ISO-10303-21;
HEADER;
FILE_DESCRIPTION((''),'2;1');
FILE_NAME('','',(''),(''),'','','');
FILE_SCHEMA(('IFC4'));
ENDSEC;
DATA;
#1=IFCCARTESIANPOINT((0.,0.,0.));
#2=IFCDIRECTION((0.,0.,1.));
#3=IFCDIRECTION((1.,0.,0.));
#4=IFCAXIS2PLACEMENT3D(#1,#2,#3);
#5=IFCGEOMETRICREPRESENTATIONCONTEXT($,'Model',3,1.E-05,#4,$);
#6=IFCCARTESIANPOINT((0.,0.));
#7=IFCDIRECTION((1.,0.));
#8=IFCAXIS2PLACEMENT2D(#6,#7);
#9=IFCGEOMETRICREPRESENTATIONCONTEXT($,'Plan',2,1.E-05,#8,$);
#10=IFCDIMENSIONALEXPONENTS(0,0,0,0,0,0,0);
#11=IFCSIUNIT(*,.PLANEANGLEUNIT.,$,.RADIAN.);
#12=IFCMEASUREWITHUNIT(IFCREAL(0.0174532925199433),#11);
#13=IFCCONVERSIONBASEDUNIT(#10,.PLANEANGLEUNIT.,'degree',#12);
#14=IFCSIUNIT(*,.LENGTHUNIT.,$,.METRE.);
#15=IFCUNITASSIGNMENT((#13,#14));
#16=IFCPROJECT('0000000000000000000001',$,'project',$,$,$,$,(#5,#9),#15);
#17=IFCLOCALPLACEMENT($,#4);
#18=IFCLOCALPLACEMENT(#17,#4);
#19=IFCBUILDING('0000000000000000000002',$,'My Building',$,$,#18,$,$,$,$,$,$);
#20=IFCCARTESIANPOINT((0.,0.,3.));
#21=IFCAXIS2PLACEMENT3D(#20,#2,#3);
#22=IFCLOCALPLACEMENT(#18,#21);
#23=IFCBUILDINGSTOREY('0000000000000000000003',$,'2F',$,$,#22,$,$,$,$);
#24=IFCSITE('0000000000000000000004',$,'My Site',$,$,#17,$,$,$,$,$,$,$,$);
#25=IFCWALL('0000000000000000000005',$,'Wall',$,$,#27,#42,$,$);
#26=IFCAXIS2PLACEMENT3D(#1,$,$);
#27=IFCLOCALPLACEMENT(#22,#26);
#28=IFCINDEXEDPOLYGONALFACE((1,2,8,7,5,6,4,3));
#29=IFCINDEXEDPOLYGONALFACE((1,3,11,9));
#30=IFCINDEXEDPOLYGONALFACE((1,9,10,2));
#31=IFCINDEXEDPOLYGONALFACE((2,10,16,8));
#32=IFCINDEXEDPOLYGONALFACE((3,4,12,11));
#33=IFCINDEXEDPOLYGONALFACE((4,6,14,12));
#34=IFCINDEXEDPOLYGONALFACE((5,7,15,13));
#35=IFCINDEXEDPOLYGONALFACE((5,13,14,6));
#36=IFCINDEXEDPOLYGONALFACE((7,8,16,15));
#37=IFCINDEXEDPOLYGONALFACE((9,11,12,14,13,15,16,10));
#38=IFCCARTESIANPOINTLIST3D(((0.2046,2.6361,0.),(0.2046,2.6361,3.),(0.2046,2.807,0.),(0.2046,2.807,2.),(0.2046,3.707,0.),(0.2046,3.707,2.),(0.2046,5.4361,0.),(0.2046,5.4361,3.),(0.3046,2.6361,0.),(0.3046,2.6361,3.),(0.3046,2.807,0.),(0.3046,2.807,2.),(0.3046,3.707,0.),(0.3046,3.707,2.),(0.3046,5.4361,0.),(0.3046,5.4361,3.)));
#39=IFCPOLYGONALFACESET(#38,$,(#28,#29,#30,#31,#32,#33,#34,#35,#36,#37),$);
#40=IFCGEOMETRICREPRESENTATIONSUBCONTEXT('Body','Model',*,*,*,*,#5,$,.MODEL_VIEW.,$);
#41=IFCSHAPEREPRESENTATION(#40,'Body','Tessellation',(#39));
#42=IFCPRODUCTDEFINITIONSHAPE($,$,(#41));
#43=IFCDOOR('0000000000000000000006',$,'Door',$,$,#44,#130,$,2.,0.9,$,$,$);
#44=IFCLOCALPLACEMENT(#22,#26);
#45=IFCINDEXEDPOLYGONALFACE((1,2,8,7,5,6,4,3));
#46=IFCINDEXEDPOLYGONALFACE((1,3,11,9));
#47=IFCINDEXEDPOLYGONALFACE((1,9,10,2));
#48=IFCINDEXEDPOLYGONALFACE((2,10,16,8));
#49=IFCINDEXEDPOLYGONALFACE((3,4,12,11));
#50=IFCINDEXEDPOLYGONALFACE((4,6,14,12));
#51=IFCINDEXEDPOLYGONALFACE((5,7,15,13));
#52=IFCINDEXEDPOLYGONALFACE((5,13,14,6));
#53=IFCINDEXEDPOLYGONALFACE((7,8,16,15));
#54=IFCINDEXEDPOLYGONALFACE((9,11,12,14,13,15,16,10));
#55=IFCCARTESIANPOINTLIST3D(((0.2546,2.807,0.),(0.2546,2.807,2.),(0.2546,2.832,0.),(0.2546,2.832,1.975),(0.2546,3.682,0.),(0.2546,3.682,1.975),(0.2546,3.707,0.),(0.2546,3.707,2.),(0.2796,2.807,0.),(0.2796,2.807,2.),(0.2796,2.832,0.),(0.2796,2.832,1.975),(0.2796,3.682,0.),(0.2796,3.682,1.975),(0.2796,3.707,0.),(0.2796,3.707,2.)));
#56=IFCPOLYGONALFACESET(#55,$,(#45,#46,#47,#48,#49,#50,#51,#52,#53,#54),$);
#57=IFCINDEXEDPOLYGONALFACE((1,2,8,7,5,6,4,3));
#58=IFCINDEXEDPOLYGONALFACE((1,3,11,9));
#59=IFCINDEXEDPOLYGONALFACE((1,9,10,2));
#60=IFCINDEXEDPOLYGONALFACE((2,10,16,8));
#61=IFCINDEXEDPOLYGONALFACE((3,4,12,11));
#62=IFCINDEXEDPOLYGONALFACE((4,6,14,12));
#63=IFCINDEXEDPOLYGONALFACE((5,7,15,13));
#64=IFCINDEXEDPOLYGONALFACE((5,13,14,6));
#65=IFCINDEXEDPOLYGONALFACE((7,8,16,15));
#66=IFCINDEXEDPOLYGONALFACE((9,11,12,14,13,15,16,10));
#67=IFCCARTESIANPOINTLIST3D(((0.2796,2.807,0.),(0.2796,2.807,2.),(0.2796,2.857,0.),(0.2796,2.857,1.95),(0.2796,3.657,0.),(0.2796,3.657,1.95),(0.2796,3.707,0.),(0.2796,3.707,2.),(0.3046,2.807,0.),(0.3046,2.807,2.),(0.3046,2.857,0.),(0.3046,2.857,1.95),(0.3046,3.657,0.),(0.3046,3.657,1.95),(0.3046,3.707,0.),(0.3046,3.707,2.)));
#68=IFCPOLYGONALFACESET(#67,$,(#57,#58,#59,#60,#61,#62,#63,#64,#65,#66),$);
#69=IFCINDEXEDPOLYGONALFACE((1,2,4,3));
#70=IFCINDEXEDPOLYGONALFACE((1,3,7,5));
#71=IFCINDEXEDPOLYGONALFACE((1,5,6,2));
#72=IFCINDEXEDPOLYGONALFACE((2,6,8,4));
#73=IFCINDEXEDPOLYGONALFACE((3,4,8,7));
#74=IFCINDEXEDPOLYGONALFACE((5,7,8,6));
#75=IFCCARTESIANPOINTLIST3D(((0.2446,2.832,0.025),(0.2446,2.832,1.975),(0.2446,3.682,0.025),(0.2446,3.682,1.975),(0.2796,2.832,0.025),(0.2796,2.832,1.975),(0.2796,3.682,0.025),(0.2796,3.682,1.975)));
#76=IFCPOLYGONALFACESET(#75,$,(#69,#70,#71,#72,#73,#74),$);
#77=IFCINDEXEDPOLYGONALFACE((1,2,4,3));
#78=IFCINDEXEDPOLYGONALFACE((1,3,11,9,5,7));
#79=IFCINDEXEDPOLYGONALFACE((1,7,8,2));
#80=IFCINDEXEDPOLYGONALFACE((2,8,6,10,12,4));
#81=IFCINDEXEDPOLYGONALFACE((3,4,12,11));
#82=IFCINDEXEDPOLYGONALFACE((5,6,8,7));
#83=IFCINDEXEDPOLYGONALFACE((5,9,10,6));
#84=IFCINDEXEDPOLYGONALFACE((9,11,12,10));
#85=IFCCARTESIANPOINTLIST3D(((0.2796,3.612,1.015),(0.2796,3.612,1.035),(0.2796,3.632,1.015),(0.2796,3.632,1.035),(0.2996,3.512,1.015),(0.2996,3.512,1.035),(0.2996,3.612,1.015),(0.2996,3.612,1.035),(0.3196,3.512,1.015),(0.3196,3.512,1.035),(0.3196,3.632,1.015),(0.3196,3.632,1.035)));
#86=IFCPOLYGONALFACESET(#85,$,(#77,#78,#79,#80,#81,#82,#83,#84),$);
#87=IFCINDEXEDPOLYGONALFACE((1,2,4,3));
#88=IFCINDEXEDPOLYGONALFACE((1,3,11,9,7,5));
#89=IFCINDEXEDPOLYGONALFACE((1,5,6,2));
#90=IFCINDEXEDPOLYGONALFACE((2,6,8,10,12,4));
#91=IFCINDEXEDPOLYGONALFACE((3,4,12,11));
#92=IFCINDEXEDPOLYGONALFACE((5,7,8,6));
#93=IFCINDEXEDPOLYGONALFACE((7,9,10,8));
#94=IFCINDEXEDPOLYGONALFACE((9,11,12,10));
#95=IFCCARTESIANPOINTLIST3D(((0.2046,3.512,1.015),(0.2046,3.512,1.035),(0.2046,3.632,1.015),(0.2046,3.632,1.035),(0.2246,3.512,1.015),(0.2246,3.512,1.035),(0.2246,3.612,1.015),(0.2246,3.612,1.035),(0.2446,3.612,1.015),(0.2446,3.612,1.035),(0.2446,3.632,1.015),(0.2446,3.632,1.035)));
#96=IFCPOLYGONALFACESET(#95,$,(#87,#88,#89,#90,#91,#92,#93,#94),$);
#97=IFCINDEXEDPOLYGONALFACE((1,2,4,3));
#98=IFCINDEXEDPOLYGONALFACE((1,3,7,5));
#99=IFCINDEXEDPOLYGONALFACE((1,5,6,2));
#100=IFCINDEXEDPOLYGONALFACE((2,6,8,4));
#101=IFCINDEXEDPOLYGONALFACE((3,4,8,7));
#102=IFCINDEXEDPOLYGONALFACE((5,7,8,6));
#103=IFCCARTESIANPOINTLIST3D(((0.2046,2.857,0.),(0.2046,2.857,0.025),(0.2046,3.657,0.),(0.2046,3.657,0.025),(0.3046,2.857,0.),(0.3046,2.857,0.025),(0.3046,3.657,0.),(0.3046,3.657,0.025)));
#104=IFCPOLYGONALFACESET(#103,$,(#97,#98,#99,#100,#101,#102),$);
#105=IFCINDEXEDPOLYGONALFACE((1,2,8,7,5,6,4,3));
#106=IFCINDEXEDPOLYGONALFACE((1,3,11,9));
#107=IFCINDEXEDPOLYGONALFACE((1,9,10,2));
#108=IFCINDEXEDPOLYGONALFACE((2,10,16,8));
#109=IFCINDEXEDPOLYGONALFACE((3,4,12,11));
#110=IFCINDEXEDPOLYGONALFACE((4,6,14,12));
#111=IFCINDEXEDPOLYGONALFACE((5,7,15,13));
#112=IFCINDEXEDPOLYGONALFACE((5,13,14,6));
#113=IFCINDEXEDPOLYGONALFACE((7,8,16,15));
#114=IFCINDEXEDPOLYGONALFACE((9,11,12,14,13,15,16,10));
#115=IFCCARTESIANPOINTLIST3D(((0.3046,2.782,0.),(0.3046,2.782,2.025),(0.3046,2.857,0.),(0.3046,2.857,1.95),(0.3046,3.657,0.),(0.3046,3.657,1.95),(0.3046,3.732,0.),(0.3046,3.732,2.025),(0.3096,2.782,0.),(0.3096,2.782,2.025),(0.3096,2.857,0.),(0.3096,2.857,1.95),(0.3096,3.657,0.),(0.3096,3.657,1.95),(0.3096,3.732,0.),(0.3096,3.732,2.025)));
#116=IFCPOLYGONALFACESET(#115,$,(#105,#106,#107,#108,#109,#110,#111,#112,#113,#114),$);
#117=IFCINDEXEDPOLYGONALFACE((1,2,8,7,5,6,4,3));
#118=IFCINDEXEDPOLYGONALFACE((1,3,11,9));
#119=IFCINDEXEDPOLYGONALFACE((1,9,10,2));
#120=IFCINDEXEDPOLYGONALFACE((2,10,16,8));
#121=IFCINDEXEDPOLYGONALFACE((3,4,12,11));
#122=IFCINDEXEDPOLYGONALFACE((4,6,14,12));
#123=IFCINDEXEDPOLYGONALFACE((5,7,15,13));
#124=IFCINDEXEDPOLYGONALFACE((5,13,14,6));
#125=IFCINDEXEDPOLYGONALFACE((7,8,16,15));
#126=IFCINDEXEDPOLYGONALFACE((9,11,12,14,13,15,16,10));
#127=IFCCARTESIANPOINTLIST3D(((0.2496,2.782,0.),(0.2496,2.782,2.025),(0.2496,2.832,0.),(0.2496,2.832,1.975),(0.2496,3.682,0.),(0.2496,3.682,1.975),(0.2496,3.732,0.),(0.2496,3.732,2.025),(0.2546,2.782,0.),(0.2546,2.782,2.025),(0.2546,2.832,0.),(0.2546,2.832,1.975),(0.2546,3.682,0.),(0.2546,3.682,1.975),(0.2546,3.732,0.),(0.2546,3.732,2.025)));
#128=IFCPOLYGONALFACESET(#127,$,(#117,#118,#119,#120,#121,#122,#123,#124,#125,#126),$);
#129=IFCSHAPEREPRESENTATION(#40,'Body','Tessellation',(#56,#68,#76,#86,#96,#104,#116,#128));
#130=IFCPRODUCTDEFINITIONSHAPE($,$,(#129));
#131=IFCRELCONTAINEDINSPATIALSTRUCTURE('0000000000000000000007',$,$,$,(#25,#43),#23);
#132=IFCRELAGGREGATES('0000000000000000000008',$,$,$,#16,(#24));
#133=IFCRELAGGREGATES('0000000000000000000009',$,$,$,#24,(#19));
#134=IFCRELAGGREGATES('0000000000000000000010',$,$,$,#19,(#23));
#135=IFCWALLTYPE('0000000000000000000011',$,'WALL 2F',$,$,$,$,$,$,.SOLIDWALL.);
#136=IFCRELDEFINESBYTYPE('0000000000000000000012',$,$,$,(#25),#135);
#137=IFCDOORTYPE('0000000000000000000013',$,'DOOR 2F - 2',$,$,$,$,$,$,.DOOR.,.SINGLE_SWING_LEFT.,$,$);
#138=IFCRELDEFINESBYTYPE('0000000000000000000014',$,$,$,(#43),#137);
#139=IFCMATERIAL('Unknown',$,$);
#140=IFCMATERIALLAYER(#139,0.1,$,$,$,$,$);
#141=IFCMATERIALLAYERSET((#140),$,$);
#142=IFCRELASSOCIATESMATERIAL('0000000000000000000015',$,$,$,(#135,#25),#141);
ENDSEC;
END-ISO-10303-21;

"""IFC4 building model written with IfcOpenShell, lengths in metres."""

from ifc_helpers import new_model, entity, si_unit, converted_unit, frame, origin_with_axes, origin_2d_with_axis, place, context, subcontext, project, spatial, line, indexed_curve, outline, extrude, shape, source, transform, mapped, material, layer, layer_set, layer_usage, type_object, type_shapes, element, fill, save


model = new_model("IFC4")

# Units and contexts
model_context = context("Model", 3, precision=1e-05, world=origin_with_axes())
plan_context = context("Plan", 2, precision=1e-05, world=origin_2d_with_axis())
body_context_1 = subcontext(model_context, "Body", "Model", "MODEL_VIEW")
body_context_2 = subcontext(plan_context, "Body", "Plan", "PLAN_VIEW")
ifc_project = project(units=[converted_unit("PLANEANGLEUNIT", "degree", entity("IfcReal", 0.0174532925199433), si_unit("PLANEANGLEUNIT", "RADIAN"), dimensions=[0, 0, 0, 0, 0, 0, 0]), si_unit("LENGTHUNIT", "METRE")], contexts=[model_context, plan_context])

# Site, building, storey
site_placement = place(None, origin_with_axes())
site = spatial("IfcSite", under=ifc_project, at=site_placement, Name="My Site")
building_placement = place(site_placement, origin_with_axes())
building = spatial("IfcBuilding", under=site, at=building_placement, Name="My Building")
storey_placement = place(building_placement, frame((0.0, 0.0, 3.0), z_axis=(0.0, 0.0, 1.0), x_axis=(1.0, 0.0, 0.0)))
storey = spatial("IfcBuildingStorey", under=building, at=storey_placement, Name="2F")

# Shared definitions
ifc_material = material(Name="Unknown")

# Shared definitions
ifc_layer_1 = layer(ifc_material, 0.1)
ifc_layer_set_1 = layer_set([ifc_layer_1])
wall_type = type_object("IfcWallType", Name="WALL 2F", PredefinedType="SOLIDWALL", material=ifc_layer_set_1)

# Wall, opening, door
ifc_layer_usage_1 = layer_usage(ifc_layer_set_1, "AXIS2", "POSITIVE", 0.0)
wall_1_placement = place(storey_placement, frame((0.3046, 2.6361, 0.0), z_axis=(0.0, 0.0, 1.0), x_axis=(0.0, 1.0, 0.0)))
wall_1 = element("IfcWall", 1, at=wall_1_placement, inside=storey, type_object=wall_type, material=ifc_layer_usage_1, Name="Wall", context=body_context_1, shape_type="SweptSolid", body=[
    extrude(outline(indexed_curve([(0.0, 0.0), (0.0, 0.1), (2.8, 0.1), (2.8, 0.0)], segments=[line(1, 2, 3, 4, 1)])), origin_with_axes(), (0.0, 0.0, 1.0), 3.0),
])
shared_shape_1 = source(origin_with_axes(), body_context_1, "Body", "SweptSolid", [
    extrude(outline(indexed_curve([(0.0, 0.0), (0.9, 0.0), (0.9, 2.0), (0.0, 2.0)], segments=[line(1, 2, 3, 4, 1)])), frame((0.0, -0.6, 0.0), z_axis=(0.0, -1.0, 0.0), x_axis=(1.0, 0.0, 0.0)), (0.0, 0.0, -1.0), 1.2),
])
opening_1_placement = place(wall_1_placement, frame((0.1709, 0.0, 0.0), z_axis=(0.0, 0.0, 1.0), x_axis=(1.0, 0.0, 0.0)))
opening_1 = element("IfcOpeningElement", 2, at=opening_1_placement, cuts=wall_1, PredefinedType="OPENING", context=body_context_1, shape_type="MappedRepresentation", body=[
    mapped(shared_shape_1, transform((0.0, 0.0, 0.0), x_axis=(1.0, 0.0, 0.0), y_axis=(0.0, 1.0, 0.0), z_axis=(0.0, 0.0, 1.0), scale=1.0)),
])
door_type = type_object("IfcDoorType", Name="DOOR 2F - 2", OperationType="SINGLE_SWING_LEFT", PredefinedType="DOOR")
shared_shape_2 = source(origin_with_axes(), body_context_1, "Body", "SweptSolid", [
    extrude(outline(indexed_curve([(0.0, 0.0), (0.0, 2.0), (0.9, 2.0), (0.9, 0.0), (0.875, 0.0), (0.875, 1.975), (0.025, 1.975), (0.025, 0.0)], segments=[line(1, 2, 3, 4, 5, 6, 7, 8, 1)])), frame((0.0, 0.025, 0.0), z_axis=(0.0, -1.0, 0.0), x_axis=(1.0, 0.0, 0.0)), (0.0, 0.0, -1.0), 0.025),
    extrude(outline(indexed_curve([(0.0, 0.0), (0.0, 2.0), (0.9, 2.0), (0.9, 0.0), (0.85, 0.0), (0.85, 1.95), (0.05, 1.95), (0.05, 0.0)], segments=[line(1, 2, 3, 4, 5, 6, 7, 8, 1)])), frame((0.0, 0.0, 0.0), z_axis=(0.0, -1.0, 0.0), x_axis=(1.0, 0.0, 0.0)), (0.0, 0.0, -1.0), 0.025),
    extrude(outline(indexed_curve([(0.0, 0.0), (0.85, 0.0), (0.85, 0.035), (0.0, 0.035)], segments=[line(1, 2, 3, 4, 1)])), frame((0.025, 0.025, 0.025), z_axis=(0.0, 0.0, 1.0), x_axis=(1.0, 0.0, 0.0)), (0.0, 0.0, 1.0), 1.95),
    extrude(outline(indexed_curve([(0.0, 0.0), (0.0, -0.04), (-0.12, -0.04), (-0.12, -0.02), (-0.02, -0.02), (-0.02, 0.0)], segments=[line(1, 2, 3, 4, 5, 6, 1)])), frame((0.825, 0.025, 1.015), z_axis=(0.0, 0.0, 1.0), x_axis=(1.0, 0.0, 0.0)), (0.0, 0.0, 1.0), 0.02),
    extrude(outline(indexed_curve([(0.0, 0.0), (0.0, 0.04), (-0.12, 0.04), (-0.12, 0.02), (-0.02, 0.02), (-0.02, 0.0)], segments=[line(1, 2, 3, 4, 5, 6, 1)])), frame((0.825, 0.06, 1.015), z_axis=(0.0, 0.0, 1.0), x_axis=(1.0, 0.0, 0.0)), (0.0, 0.0, 1.0), 0.02),
    extrude(outline(indexed_curve([(0.0, 0.0), (0.8, 0.0), (0.8, 0.1), (0.0, 0.1)], segments=[line(1, 2, 3, 4, 1)])), frame((0.05, 0.0, 0.0), z_axis=(0.0, 0.0, 1.0), x_axis=(1.0, 0.0, 0.0)), (0.0, 0.0, 1.0), 0.025),
    extrude(outline(indexed_curve([(0.0, 0.0), (0.0, 2.025), (0.95, 2.025), (0.95, 0.0), (0.875, 0.0), (0.875, 1.95), (0.075, 1.95), (0.075, 0.0)], segments=[line(1, 2, 3, 4, 5, 6, 7, 8, 1)])), frame((-0.025, -0.005, 0.0), z_axis=(0.0, -1.0, 0.0), x_axis=(1.0, 0.0, 0.0)), (0.0, 0.0, -1.0), 0.005),
    extrude(outline(indexed_curve([(0.0, 0.0), (0.0, 2.025), (0.95, 2.025), (0.95, 0.0), (0.9, 0.0), (0.9, 1.975), (0.05, 1.975), (0.05, 0.0)], segments=[line(1, 2, 3, 4, 5, 6, 7, 8, 1)])), frame((-0.025, 0.05, 0.0), z_axis=(0.0, -1.0, 0.0), x_axis=(1.0, 0.0, 0.0)), (0.0, 0.0, -1.0), 0.005),
])
shared_shape_3 = source(origin_with_axes(), body_context_2, "Body", "Curve2D", [
    entity("IfcIndexedPolyCurve", entity("IfcCartesianPointList2D", [[0.0, 0.0], [0.0, 0.05], [0.025, 0.05], [0.025, 0.025], [0.05, 0.025], [0.05, 0.0]]), [entity("IfcLineIndex", [1, 2, 3, 4, 5, 6, 1])]),
    entity("IfcIndexedPolyCurve", entity("IfcCartesianPointList2D", [[0.9, 0.0], [0.9, 0.05], [0.875, 0.05], [0.875, 0.025], [0.85, 0.025], [0.85, 0.0]]), [entity("IfcLineIndex", [1, 2, 3, 4, 5, 6, 1])]),
    entity("IfcTrimmedCurve", entity("IfcEllipse", entity("IfcAxis2Placement2D", entity("IfcCartesianPoint", [0.06, 0.05]), entity("IfcDirection", [1.0, 0.0])), 0.815, 0.85), [entity("IfcCartesianPoint", [0.875, 0.05])], [entity("IfcCartesianPoint", [0.06, 0.9])], True, "CARTESIAN"),
    entity("IfcIndexedPolyCurve", entity("IfcCartesianPointList2D", [[0.025, 0.05], [0.06, 0.05], [0.06, 0.9], [0.025, 0.9]]), [entity("IfcLineIndex", [1, 2, 3, 4, 1])]),
])
type_shapes(door_type, [shared_shape_2, shared_shape_3])
door_1_placement = place(opening_1_placement, origin_with_axes())
door_1 = element("IfcDoor", 3, at=door_1_placement, inside=storey, type_object=door_type, Name="Door", OverallHeight=2.0, OverallWidth=0.9, shapes=[
    shape(body_context_1, "Body", "MappedRepresentation", [mapped(shared_shape_2, transform((0.0, 0.0, 0.0), x_axis=(1.0, 0.0, 0.0), y_axis=(0.0, 1.0, 0.0), z_axis=(0.0, 0.0, 1.0), scale=1.0))]),
    shape(body_context_2, "Body", "MappedRepresentation", [mapped(shared_shape_3, transform((0.0, 0.0, 0.0), x_axis=(1.0, 0.0, 0.0), y_axis=(0.0, 1.0, 0.0), z_axis=(0.0, 0.0, 1.0), scale=1.0))]),
])
fill(opening_1, door_1)

save(model, "model.ifc")
